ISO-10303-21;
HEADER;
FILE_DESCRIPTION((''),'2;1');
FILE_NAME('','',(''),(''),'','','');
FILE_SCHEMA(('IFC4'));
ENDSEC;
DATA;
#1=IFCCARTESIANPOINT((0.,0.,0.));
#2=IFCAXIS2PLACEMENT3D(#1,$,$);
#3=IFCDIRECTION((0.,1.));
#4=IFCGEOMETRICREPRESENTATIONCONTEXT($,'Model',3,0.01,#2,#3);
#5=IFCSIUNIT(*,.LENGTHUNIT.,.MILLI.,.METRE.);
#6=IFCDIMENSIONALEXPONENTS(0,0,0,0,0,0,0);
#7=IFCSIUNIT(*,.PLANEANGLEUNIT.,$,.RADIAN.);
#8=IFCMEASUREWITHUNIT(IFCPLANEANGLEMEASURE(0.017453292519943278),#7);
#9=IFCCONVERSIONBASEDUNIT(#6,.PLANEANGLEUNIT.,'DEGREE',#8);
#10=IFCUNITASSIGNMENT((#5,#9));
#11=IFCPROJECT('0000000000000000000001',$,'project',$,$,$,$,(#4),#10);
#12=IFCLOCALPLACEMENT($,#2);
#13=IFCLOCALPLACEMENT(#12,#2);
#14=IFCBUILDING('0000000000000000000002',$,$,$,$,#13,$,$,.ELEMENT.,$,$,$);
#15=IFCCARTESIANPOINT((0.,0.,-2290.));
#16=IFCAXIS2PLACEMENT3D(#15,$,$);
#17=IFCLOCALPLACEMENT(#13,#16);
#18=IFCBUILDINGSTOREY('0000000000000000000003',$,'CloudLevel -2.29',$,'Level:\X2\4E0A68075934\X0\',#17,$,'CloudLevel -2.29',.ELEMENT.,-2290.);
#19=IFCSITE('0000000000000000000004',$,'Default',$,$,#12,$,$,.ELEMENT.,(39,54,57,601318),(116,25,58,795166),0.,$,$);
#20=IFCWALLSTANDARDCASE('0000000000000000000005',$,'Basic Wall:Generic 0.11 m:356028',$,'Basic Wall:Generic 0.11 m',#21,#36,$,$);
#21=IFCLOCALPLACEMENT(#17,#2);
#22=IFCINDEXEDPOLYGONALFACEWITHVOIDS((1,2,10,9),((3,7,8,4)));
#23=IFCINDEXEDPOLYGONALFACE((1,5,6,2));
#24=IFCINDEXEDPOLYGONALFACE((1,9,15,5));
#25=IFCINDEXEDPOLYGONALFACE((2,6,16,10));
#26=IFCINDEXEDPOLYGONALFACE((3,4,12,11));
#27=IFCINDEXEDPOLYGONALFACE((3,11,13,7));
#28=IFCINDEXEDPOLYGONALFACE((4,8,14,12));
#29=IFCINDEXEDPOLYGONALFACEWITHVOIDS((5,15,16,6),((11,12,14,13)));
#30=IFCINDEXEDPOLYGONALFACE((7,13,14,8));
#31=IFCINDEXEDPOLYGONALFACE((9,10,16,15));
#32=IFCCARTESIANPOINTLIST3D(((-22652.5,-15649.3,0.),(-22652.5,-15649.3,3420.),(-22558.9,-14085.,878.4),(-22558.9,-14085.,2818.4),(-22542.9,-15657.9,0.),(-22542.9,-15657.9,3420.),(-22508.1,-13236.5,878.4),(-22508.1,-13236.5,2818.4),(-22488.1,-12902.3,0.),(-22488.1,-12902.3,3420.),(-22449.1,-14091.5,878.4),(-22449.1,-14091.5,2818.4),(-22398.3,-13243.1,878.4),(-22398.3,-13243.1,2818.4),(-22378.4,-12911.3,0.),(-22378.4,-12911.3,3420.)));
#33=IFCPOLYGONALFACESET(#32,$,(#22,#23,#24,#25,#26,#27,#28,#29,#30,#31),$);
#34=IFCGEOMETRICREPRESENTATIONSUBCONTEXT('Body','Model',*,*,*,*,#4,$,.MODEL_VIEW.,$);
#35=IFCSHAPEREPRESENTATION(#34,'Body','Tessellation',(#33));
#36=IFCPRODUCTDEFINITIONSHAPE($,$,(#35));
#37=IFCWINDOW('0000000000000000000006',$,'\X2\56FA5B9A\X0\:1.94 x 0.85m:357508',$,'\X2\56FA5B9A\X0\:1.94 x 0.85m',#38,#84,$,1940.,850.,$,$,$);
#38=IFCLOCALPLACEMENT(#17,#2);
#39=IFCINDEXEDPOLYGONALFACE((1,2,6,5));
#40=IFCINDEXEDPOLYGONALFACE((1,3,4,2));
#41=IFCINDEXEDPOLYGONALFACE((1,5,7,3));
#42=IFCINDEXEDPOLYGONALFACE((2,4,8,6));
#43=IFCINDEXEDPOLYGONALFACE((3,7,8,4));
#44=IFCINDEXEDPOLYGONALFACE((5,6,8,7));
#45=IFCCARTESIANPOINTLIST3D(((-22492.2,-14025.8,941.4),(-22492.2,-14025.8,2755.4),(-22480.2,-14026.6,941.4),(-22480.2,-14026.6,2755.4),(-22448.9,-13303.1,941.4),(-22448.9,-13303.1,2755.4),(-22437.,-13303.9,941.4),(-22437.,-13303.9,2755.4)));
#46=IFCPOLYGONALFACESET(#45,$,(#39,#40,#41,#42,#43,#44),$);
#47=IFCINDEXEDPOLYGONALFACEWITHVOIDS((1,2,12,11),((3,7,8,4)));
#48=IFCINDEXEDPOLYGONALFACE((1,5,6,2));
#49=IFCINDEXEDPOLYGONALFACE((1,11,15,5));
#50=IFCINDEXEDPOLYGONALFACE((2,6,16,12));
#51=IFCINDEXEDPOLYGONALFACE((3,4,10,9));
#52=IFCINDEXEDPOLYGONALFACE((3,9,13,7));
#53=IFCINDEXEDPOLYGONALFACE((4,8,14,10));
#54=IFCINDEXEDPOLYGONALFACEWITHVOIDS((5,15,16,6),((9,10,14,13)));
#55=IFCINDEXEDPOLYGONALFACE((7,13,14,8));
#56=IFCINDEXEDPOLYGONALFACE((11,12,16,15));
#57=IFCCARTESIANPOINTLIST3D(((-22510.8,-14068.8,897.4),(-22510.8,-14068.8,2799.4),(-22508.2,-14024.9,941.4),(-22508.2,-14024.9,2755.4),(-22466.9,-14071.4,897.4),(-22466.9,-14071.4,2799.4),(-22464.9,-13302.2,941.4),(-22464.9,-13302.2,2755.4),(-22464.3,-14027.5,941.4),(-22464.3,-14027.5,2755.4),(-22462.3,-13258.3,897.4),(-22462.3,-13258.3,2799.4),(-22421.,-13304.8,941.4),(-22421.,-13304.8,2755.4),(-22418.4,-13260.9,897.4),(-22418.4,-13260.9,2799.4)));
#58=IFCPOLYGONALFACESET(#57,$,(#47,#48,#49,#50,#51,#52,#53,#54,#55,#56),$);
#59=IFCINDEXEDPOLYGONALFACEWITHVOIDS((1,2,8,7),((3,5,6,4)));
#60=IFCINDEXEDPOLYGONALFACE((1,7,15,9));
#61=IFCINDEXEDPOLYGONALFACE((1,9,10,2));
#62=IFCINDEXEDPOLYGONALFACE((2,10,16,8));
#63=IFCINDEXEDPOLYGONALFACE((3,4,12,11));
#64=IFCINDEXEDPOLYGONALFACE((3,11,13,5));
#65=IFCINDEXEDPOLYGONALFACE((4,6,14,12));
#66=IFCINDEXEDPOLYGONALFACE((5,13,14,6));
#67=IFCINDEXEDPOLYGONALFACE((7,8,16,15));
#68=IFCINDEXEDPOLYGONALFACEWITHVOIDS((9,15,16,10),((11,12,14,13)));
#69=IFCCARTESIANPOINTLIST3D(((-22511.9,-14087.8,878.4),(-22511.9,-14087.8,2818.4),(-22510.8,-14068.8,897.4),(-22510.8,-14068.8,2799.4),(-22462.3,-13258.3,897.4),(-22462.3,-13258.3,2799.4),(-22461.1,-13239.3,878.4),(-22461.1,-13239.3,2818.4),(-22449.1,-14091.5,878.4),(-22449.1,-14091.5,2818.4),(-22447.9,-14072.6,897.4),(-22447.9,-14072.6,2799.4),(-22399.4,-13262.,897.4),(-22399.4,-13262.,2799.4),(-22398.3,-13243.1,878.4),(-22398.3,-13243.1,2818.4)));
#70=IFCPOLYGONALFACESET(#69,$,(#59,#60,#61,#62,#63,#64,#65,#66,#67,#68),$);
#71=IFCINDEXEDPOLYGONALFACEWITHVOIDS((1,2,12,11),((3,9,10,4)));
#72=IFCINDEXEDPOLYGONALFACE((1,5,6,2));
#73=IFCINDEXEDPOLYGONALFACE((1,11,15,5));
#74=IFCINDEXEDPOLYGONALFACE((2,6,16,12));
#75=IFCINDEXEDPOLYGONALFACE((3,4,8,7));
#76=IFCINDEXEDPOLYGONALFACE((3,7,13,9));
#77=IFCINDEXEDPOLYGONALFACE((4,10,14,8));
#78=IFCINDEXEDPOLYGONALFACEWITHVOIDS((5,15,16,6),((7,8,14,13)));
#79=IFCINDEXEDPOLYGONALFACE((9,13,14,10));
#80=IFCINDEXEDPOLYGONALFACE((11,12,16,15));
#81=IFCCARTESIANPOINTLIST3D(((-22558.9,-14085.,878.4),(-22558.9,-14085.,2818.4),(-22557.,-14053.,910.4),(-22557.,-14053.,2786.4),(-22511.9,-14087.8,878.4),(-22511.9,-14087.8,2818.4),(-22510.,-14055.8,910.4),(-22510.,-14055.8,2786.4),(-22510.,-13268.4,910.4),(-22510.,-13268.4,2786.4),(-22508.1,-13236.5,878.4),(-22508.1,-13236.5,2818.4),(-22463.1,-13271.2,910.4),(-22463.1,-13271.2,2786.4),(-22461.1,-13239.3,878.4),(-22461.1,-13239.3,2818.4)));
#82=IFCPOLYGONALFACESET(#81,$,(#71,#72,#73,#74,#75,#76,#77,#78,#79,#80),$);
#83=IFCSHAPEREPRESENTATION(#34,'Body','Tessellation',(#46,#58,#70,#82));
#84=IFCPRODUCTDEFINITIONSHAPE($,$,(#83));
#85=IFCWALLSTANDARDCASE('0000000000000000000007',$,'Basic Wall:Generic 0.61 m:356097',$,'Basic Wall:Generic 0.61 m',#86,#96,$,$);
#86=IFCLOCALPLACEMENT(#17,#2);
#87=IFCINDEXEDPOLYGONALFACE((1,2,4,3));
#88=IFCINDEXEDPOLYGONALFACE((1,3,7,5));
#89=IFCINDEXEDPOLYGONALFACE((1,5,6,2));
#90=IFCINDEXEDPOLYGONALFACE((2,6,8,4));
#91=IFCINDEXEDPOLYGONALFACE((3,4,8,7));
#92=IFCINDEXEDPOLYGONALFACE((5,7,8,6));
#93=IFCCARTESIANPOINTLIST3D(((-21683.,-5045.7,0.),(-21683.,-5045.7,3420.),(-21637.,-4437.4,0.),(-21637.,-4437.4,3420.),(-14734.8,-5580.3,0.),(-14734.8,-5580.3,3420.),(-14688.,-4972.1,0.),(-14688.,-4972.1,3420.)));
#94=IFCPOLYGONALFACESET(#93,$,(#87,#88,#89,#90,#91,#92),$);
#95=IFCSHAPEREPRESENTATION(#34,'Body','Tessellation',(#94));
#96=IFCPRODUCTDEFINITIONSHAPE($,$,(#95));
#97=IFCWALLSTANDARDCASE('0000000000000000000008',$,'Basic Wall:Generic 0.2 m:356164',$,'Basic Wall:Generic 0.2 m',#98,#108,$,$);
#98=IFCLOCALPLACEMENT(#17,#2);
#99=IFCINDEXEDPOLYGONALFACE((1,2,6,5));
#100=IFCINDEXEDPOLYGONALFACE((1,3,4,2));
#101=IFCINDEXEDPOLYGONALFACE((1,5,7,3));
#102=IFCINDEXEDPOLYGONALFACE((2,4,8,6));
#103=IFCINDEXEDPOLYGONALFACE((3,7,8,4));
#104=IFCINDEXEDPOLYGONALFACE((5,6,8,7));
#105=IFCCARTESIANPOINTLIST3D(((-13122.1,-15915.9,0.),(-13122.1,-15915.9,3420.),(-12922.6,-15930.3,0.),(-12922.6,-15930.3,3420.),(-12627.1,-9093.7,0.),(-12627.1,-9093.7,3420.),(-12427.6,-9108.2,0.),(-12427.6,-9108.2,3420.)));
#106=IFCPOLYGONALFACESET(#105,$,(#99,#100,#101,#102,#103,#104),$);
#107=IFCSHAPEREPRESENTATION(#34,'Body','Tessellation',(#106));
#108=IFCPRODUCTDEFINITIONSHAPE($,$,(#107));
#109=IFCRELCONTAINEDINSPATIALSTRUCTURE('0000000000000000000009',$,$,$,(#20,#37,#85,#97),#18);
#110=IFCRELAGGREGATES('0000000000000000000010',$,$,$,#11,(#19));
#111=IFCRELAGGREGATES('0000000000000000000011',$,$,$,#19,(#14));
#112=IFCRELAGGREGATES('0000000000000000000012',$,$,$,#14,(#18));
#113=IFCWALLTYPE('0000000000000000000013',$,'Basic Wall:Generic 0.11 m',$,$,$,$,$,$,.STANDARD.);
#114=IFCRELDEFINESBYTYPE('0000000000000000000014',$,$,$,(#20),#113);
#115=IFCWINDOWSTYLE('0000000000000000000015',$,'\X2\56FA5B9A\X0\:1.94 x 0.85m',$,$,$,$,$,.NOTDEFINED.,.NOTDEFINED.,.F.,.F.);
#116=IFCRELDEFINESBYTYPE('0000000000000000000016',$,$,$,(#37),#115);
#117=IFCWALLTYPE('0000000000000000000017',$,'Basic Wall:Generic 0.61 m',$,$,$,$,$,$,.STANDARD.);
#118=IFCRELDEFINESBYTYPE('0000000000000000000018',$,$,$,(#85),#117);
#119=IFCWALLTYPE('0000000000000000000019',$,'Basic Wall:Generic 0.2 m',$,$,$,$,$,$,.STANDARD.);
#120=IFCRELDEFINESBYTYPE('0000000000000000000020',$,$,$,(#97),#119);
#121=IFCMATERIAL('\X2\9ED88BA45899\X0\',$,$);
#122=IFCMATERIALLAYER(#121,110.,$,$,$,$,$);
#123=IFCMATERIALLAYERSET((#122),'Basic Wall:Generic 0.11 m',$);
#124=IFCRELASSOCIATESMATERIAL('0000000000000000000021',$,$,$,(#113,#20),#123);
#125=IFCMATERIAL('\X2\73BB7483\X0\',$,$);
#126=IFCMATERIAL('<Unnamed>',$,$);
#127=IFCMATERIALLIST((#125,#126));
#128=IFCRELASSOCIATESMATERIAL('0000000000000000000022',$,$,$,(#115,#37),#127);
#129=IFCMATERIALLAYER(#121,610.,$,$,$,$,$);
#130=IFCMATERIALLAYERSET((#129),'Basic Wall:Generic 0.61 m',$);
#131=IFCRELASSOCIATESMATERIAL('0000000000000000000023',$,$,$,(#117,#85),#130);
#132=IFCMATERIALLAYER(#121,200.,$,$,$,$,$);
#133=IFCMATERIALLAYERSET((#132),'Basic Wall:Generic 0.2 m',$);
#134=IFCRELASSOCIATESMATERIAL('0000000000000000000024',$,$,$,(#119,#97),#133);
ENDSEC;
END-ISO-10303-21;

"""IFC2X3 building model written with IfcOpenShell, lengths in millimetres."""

from ifc_helpers import new_model, entity, si_unit, converted_unit, direction, frame, frame_2d, origin, origin_2d_with_axis, place, context, subcontext, project, spatial, polyline, rectangle, outline, extrude, source, transform, mapped, material, material_list, layer, layer_set, layer_usage, type_object, type_shapes, element, fill, save


model = new_model("IFC2X3")

# Units and contexts
model_context = context("Model", 3, precision=0.01, world=origin(), true_north=direction((0.0, 1.0)))
body_context = subcontext(model_context, "Body", "Model", "MODEL_VIEW")
ifc_project = project(units=[si_unit("LENGTHUNIT", "METRE", prefix="MILLI"), converted_unit("PLANEANGLEUNIT", "DEGREE", entity("IfcPlaneAngleMeasure", 0.017453292519943278), si_unit("PLANEANGLEUNIT", "RADIAN"), dimensions=[0, 0, 0, 0, 0, 0, 0])], contexts=[model_context])

# Site, building, storey
site_placement = place(None, origin())
site = spatial("IfcSite", under=ifc_project, at=site_placement, Name="Default", CompositionType="ELEMENT", RefLatitude=(39, 54, 57, 601318), RefLongitude=(116, 25, 58, 795166), RefElevation=0.0)
building_placement = place(site_placement, origin())
building = spatial("IfcBuilding", under=site, at=building_placement, CompositionType="ELEMENT")
storey_placement = place(building_placement, frame((0.0, 0.0, -2290.0)))
storey = spatial("IfcBuildingStorey", under=building, at=storey_placement, Name="CloudLevel -2.29", ObjectType="Level:上标头", LongName="CloudLevel -2.29", CompositionType="ELEMENT", Elevation=-2290.0)

# Shared definitions
ifc_material_1 = material(Name="默认墙")

# Shared definitions
ifc_material_2 = material(Name="玻璃")
ifc_material_3 = material(Name="<Unnamed>")
ifc_material_list = material_list([ifc_material_2, ifc_material_3])

# Wall, opening, window
ifc_layer_1 = layer(ifc_material_1, 110.0)
ifc_layer_set_1 = layer_set([ifc_layer_1], Name="Basic Wall:Generic 0.11 m")
ifc_layer_usage_1 = layer_usage(ifc_layer_set_1, "AXIS2", "NEGATIVE", 55.0)
wall_type_1 = type_object("IfcWallType", Name="Basic Wall:Generic 0.11 m", PredefinedType="STANDARD", material=ifc_layer_set_1)
wall_1_placement = place(storey_placement, frame((-22597.8, -15654.6, 0.0), z_axis=(0.0, 0.0, 1.0), x_axis=(0.05977, 0.998212, 0.0)))
wall_1 = element("IfcWallStandardCase", 1, at=wall_1_placement, inside=storey, type_object=wall_type_1, material=ifc_layer_usage_1, Name="Basic Wall:Generic 0.11 m:356028", ObjectType="Basic Wall:Generic 0.11 m", context=body_context, shape_type="SweptSolid", body=[
    extrude(outline(polyline([(2751.5, -55.0), (2753.9, 55.0), (2.0, 55.0), (0.0, -55.0), (240.0, -55.0), (2511.5, -55.0), (2751.5, -55.0)])), origin(), (0.0, 0.0, 1.0), 3420.0),
])
opening_1_placement = place(wall_1_placement, frame((2419.2, 55.0, 878.4)))
opening_1 = element("IfcOpeningElement", 2, at=opening_1_placement, cuts=wall_1, ObjectType="Opening", context=body_context, shape_type="SweptSolid", body=[
    extrude(rectangle(XDim=1940.0, YDim=850.0, at=frame_2d((970.0, 425.0), x_axis=(1.0, 0.0))), frame((0.0, 0.0, 0.0), z_axis=(0.0, -1.0, 0.0), x_axis=(0.0, 0.0, 1.0)), (0.0, 0.0, 1.0), 110.0),
])
window_style_1 = type_object("IfcWindowStyle", Name="固定:1.94 x 0.85m", ConstructionType="NOTDEFINED", OperationType="NOTDEFINED", ParameterTakesPrecedence=False, Sizeable=False, material=ifc_material_list)
shared_shape_1 = source(origin(), body_context, "Body", "SweptSolid", [
    extrude(rectangle(XDim=724.0, YDim=12.0, at=origin_2d_with_axis()), frame((425.0, 95.0, 63.0), z_axis=(0.0, 0.0, 1.0), x_axis=(-1.0, 0.0, 0.0)), (0.0, 0.0, 1.0), 1814.0),
    extrude(outline(polyline([(-406.0, -951.0), (406.0, -951.0), (406.0, 951.0), (-406.0, 951.0), (-406.0, -951.0)]), holes=[polyline([(-362.0, -907.0), (-362.0, 907.0), (362.0, 907.0), (362.0, -907.0), (-362.0, -907.0)])]), frame((425.0, 117.0, 970.0), z_axis=(0.0, -1.0, 0.0), x_axis=(-1.0, 0.0, 0.0)), (0.0, 0.0, 1.0), 44.0),
    extrude(outline(polyline([(-425.0, -970.0), (425.0, -970.0), (425.0, 970.0), (-425.0, 970.0), (-425.0, -970.0)]), holes=[polyline([(-406.0, -951.0), (-406.0, 951.0), (406.0, 951.0), (406.0, -951.0), (-406.0, -951.0)])]), frame((425.0, 136.0, 970.0), z_axis=(0.0, -1.0, 0.0), x_axis=(-1.0, 0.0, 0.0)), (0.0, 0.0, 1.0), 63.0),
    extrude(outline(polyline([(-425.0, -970.0), (425.0, -970.0), (425.0, 970.0), (-425.0, 970.0), (-425.0, -970.0)]), holes=[polyline([(-393.0, -938.0), (-393.0, 938.0), (393.0, 938.0), (393.0, -938.0), (-393.0, -938.0)])]), frame((425.0, 73.0, 970.0), z_axis=(0.0, -1.0, 0.0), x_axis=(-1.0, 0.0, 0.0)), (0.0, 0.0, 1.0), 47.0),
])
type_shapes(window_style_1, [shared_shape_1])
window_1_placement = place(opening_1_placement, frame((0.0, 26.0, 0.0), z_axis=(0.0, 0.0, 1.0), x_axis=(-1.0, 0.0, 0.0)))
window_1 = element("IfcWindow", 3, at=window_1_placement, inside=storey, type_object=window_style_1, material=ifc_material_list, Name="固定:1.94 x 0.85m:357508", ObjectType="固定:1.94 x 0.85m", OverallHeight=1940.0, OverallWidth=850.0, context=body_context, shape_type="MappedRepresentation", body=[
    mapped(shared_shape_1, transform((0.0, 0.0, 0.0), scale=1.0)),
])
fill(opening_1, window_1)

# Walls
ifc_layer_2 = layer(ifc_material_1, 610.0)
ifc_layer_set_2 = layer_set([ifc_layer_2], Name="Basic Wall:Generic 0.61 m")
ifc_layer_usage_2 = layer_usage(ifc_layer_set_2, "AXIS2", "NEGATIVE", 305.0)
wall_type_2 = type_object("IfcWallType", Name="Basic Wall:Generic 0.61 m", PredefinedType="STANDARD", material=ifc_layer_set_2)
wall_2_placement = place(storey_placement, frame((-21660.4, -4741.5, 0.0), z_axis=(0.0, 0.0, 1.0), x_axis=(0.997052, -0.076725, 0.0)))
element("IfcWallStandardCase", 4, at=wall_2_placement, inside=storey, type_object=wall_type_2, material=ifc_layer_usage_2, Name="Basic Wall:Generic 0.61 m:356097", ObjectType="Basic Wall:Generic 0.61 m", context=body_context, shape_type="SweptSolid", body=[
    extrude(outline(polyline([(6969.5, -305.0), (6969.6, 305.0), (0.0, 305.0), (0.9, -305.0), (6969.5, -305.0)])), origin(), (0.0, 0.0, 1.0), 3420.0),
])
ifc_layer_3 = layer(ifc_material_1, 200.0)
ifc_layer_set_3 = layer_set([ifc_layer_3], Name="Basic Wall:Generic 0.2 m")
ifc_layer_usage_3 = layer_usage(ifc_layer_set_3, "AXIS2", "NEGATIVE", 100.0)
wall_type_3 = type_object("IfcWallType", Name="Basic Wall:Generic 0.2 m", PredefinedType="STANDARD", material=ifc_layer_set_3)
wall_3_placement = place(storey_placement, frame((-13022.4, -15923.1, 0.0), z_axis=(0.0, 0.0, 1.0), x_axis=(0.072371, 0.997378, 0.0)))
element("IfcWallStandardCase", 5, at=wall_3_placement, inside=storey, type_object=wall_type_3, material=ifc_layer_usage_3, Name="Basic Wall:Generic 0.2 m:356164", ObjectType="Basic Wall:Generic 0.2 m", context=body_context, shape_type="SweptSolid", body=[
    extrude(rectangle(XDim=6840.1, YDim=200.0, at=frame_2d((3420.1, 0.0), x_axis=(-1.0, 0.0))), origin(), (0.0, 0.0, 1.0), 3420.0),
])

save(model, "model.ifc")
